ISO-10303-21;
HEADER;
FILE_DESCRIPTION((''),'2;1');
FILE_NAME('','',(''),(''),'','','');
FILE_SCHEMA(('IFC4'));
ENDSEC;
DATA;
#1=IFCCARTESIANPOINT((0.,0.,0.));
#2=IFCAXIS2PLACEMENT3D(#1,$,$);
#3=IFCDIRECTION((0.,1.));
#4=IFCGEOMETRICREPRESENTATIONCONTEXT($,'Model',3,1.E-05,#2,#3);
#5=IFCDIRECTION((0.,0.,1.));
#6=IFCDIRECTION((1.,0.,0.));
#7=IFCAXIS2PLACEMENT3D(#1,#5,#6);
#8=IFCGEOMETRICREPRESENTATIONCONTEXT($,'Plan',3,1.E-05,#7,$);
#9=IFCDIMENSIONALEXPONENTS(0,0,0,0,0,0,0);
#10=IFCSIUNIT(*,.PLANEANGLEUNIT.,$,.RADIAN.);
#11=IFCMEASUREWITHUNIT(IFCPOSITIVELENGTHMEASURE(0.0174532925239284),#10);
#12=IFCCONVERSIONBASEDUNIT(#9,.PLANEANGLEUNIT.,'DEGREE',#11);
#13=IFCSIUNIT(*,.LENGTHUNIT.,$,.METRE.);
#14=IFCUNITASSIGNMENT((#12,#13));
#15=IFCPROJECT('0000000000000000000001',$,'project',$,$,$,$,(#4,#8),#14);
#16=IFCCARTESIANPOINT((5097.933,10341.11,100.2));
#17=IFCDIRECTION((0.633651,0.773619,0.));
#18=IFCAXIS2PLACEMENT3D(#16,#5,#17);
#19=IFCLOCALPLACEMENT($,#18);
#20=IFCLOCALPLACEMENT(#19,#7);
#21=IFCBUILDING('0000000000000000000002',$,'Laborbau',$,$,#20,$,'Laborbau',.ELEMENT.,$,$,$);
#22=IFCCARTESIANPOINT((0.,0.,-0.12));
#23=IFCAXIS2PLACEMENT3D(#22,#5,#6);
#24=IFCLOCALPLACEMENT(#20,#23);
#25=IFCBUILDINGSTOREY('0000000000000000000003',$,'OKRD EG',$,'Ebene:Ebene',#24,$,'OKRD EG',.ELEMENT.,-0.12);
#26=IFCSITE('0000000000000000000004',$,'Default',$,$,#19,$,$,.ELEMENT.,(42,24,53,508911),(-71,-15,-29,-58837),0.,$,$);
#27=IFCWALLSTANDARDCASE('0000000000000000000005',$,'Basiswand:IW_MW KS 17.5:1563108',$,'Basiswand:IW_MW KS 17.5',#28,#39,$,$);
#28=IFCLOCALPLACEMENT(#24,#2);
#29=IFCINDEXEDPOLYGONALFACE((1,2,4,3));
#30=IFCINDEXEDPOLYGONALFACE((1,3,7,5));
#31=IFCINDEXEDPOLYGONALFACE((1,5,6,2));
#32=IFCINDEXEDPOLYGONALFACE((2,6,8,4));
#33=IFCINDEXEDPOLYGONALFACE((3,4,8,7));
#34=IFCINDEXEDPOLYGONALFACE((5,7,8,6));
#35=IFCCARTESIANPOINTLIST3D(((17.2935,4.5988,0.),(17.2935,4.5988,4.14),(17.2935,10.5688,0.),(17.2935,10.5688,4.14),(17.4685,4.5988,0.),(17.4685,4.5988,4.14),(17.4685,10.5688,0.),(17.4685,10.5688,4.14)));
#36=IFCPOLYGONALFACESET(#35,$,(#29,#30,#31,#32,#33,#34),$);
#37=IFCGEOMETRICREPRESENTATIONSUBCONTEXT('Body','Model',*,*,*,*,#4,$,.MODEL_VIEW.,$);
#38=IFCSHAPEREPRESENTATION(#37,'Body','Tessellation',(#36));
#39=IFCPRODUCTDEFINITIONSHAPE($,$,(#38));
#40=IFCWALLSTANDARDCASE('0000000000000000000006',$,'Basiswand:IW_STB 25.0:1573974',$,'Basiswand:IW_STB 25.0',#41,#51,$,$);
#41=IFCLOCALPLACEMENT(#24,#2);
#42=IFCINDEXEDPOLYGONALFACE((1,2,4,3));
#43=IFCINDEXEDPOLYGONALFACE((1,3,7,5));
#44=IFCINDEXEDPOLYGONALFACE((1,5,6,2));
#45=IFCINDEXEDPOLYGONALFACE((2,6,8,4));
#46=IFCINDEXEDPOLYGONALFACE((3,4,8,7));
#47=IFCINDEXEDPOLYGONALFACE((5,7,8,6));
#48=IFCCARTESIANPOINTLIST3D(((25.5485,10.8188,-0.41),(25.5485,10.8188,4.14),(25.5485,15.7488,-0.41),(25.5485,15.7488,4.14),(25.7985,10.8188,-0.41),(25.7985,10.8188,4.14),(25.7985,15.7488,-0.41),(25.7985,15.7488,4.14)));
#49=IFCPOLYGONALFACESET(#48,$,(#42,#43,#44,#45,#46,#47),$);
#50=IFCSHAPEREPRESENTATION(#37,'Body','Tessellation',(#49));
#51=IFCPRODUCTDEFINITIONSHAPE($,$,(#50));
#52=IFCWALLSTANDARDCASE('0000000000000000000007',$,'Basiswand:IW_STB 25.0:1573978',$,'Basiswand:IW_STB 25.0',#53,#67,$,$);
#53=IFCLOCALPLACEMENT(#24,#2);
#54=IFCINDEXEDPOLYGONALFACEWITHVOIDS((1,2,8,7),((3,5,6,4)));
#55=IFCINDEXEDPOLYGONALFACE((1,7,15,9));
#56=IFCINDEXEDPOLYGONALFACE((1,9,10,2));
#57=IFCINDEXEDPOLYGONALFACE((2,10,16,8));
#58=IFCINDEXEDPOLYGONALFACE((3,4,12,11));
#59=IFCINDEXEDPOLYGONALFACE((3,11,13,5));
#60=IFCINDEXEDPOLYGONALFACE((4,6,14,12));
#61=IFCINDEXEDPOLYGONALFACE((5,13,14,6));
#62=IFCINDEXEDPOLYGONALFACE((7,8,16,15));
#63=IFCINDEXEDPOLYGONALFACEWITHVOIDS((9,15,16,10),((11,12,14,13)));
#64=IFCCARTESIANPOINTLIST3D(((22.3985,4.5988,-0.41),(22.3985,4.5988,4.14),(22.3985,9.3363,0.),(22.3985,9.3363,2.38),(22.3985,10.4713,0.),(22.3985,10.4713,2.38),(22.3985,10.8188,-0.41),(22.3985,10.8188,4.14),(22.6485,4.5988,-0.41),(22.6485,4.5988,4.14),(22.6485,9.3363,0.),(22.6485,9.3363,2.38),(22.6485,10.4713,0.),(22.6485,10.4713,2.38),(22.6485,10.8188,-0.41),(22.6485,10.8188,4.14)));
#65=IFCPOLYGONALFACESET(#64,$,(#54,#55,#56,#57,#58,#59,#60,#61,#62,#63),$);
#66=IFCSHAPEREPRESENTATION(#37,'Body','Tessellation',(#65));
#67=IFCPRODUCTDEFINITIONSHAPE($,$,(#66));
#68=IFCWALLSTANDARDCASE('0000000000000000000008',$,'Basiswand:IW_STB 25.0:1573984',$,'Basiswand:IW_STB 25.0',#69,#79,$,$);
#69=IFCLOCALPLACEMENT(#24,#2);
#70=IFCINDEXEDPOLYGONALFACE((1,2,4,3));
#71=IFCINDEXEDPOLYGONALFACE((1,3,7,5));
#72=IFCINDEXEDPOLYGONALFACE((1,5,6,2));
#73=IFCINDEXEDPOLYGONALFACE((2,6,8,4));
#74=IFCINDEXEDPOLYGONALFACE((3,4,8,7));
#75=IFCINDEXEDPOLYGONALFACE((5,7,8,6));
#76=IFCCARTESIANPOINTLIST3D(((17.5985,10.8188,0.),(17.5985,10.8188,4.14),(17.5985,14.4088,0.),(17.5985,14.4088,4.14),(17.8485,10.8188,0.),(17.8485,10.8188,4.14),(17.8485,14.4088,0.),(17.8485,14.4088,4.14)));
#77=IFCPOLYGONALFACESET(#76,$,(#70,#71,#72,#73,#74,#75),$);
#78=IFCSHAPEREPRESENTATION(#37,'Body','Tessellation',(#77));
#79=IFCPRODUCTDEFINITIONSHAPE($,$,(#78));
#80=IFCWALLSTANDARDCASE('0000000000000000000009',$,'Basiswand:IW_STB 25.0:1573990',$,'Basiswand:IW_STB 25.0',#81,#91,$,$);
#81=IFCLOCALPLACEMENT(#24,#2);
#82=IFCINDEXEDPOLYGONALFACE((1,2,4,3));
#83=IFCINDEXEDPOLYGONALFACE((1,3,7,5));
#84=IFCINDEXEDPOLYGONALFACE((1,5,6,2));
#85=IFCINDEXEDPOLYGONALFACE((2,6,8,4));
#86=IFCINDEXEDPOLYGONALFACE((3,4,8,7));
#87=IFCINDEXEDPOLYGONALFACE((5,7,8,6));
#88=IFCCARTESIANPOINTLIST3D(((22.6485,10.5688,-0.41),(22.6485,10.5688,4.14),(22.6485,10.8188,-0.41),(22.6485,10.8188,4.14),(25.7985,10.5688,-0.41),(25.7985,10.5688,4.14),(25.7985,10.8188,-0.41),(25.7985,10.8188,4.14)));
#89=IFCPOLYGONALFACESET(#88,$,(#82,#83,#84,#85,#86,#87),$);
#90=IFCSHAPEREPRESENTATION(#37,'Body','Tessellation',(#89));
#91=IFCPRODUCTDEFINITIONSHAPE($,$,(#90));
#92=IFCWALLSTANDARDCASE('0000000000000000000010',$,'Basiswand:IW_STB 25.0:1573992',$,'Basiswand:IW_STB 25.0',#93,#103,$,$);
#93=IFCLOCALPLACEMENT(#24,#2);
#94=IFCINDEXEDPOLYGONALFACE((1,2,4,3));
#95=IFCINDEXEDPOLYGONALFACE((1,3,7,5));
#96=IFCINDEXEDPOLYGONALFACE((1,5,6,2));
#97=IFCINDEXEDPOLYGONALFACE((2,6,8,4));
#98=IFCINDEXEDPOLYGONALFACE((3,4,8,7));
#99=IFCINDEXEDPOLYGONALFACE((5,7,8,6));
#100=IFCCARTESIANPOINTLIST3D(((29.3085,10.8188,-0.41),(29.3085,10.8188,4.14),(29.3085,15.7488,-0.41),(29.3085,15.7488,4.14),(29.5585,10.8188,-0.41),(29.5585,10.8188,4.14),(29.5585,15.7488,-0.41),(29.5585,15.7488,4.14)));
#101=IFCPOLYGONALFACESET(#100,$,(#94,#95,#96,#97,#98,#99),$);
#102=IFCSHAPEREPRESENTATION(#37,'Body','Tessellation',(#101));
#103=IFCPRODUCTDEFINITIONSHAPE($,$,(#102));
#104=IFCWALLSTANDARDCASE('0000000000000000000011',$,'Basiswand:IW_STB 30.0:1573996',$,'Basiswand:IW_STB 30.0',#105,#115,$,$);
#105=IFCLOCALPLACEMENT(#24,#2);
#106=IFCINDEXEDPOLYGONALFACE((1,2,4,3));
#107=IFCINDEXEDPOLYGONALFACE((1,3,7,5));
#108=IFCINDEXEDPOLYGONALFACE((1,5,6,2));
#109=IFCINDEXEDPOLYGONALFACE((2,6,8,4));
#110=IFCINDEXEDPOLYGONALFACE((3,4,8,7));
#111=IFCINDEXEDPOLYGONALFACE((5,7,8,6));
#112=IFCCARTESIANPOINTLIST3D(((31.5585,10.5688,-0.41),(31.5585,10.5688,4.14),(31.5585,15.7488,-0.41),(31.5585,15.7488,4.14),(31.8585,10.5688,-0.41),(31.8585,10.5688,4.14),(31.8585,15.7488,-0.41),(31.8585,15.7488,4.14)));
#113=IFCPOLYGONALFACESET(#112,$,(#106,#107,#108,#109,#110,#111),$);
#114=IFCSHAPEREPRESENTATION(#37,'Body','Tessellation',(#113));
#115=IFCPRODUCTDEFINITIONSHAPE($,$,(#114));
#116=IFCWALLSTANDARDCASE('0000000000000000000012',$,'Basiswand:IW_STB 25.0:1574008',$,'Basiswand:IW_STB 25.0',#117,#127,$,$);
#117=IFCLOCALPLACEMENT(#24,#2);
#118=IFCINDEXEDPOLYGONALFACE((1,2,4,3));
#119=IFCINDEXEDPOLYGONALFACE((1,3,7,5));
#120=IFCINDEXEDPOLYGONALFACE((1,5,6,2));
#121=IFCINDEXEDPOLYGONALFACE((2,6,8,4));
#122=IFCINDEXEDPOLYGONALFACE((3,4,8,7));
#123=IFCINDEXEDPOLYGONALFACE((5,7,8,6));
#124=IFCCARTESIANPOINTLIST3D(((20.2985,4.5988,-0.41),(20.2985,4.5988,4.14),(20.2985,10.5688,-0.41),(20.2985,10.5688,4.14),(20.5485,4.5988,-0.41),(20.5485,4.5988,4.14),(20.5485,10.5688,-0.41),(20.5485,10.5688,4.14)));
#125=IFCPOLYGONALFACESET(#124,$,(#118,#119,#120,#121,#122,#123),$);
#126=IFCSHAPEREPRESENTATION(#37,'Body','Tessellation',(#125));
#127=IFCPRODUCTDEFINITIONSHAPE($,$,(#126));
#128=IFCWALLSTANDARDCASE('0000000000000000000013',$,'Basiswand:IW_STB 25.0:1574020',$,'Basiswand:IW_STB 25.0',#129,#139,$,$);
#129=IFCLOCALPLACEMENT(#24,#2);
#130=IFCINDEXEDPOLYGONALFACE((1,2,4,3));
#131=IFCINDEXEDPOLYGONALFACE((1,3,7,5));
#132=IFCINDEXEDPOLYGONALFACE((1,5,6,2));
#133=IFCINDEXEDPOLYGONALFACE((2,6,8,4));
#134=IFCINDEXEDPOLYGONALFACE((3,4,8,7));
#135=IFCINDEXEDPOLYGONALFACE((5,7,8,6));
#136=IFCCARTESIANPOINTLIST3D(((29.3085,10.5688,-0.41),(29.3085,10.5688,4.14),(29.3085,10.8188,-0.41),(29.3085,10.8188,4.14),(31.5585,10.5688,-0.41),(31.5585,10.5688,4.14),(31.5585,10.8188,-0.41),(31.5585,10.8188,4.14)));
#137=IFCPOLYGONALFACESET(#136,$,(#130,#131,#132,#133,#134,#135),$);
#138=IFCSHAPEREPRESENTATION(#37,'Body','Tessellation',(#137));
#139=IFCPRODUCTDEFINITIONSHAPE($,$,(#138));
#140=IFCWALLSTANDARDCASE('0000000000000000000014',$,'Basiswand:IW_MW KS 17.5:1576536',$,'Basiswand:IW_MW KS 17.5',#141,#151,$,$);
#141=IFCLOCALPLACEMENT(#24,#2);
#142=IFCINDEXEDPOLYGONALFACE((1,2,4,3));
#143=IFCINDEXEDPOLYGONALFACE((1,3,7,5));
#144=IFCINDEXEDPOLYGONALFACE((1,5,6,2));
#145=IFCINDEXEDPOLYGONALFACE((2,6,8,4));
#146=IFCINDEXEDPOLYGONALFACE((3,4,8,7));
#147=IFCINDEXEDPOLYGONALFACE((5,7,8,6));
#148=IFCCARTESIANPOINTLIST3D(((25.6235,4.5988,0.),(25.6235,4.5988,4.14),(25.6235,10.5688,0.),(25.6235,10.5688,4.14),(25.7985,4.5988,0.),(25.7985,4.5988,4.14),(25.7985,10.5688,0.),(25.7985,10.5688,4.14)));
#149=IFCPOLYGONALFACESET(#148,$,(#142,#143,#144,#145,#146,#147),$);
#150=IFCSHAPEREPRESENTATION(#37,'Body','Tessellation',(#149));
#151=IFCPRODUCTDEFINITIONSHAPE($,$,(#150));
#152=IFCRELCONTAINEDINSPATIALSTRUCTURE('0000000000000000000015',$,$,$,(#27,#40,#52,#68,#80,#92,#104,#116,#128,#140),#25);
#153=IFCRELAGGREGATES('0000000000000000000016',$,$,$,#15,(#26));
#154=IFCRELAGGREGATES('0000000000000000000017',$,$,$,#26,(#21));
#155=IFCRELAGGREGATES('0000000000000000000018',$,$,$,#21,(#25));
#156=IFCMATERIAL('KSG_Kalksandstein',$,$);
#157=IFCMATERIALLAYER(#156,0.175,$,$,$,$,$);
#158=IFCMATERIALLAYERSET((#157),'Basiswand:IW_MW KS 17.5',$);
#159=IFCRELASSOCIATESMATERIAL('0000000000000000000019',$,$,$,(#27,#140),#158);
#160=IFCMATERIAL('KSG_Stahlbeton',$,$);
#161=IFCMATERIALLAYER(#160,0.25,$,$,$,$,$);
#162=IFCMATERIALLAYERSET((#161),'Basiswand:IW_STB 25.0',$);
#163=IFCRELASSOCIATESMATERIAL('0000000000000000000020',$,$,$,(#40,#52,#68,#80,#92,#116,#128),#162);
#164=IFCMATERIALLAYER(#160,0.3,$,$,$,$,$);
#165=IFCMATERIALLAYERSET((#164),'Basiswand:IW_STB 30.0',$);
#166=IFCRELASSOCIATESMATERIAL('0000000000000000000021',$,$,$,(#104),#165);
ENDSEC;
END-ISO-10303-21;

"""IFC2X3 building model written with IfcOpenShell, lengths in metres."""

from ifc_helpers import new_model, entity, si_unit, converted_unit, direction, frame, frame_2d, origin, origin_with_axes, place, context, subcontext, project, spatial, rectangle, extrude, clip, halfspace, material, layer, layer_set, layer_usage, element, save


model = new_model("IFC2X3")

# Units and contexts
model_context = context("Model", 3, precision=1e-05, world=origin(), true_north=direction((0.0, 1.0)))
plan_context = context("Plan", 3, precision=1e-05, world=origin_with_axes())
body_context = subcontext(model_context, "Body", "Model", "MODEL_VIEW")
ifc_project = project(units=[converted_unit("PLANEANGLEUNIT", "DEGREE", entity("IfcPositiveLengthMeasure", 0.0174532925239284), si_unit("PLANEANGLEUNIT", "RADIAN"), dimensions=[0, 0, 0, 0, 0, 0, 0]), si_unit("LENGTHUNIT", "METRE")], contexts=[model_context, plan_context])

# Site, building, storey
site_placement = place(None, frame((5097.933, 10341.11, 100.2), z_axis=(0.0, 0.0, 1.0), x_axis=(0.633651, 0.773619, 0.0)))
site = spatial("IfcSite", under=ifc_project, at=site_placement, Name="Default", CompositionType="ELEMENT", RefLatitude=(42, 24, 53, 508911), RefLongitude=(-71, -15, -29, -58837), RefElevation=0.0)
building_placement = place(site_placement, origin_with_axes())
building = spatial("IfcBuilding", under=site, at=building_placement, Name="Laborbau", LongName="Laborbau", CompositionType="ELEMENT")
storey_placement = place(building_placement, frame((0.0, 0.0, -0.12), z_axis=(0.0, 0.0, 1.0), x_axis=(1.0, 0.0, 0.0)))
storey = spatial("IfcBuildingStorey", under=building, at=storey_placement, Name="OKRD EG", ObjectType="Ebene:Ebene", LongName="OKRD EG", CompositionType="ELEMENT", Elevation=-0.12)

# Walls
ifc_material_1 = material(Name="KSG_Kalksandstein")
ifc_layer_1 = layer(ifc_material_1, 0.175)
ifc_layer_set_1 = layer_set([ifc_layer_1], Name="Basiswand:IW_MW KS 17.5")
ifc_layer_usage_1 = layer_usage(ifc_layer_set_1, "AXIS2", "NEGATIVE", 0.0875)
wall_1_placement = place(storey_placement, frame((17.381, 10.5688, 0.0), z_axis=(0.0, 0.0, 1.0), x_axis=(0.0, -1.0, 0.0)))
element("IfcWallStandardCase", 1, at=wall_1_placement, inside=storey, material=ifc_layer_usage_1, Name="Basiswand:IW_MW KS 17.5:1563108", ObjectType="Basiswand:IW_MW KS 17.5", context=body_context, shape_type="SweptSolid", body=[
    extrude(rectangle(XDim=5.97, YDim=0.175, at=frame_2d((2.985, 0.0), x_axis=(-1.0, 0.0))), origin(), (0.0, 0.0, 1.0), 4.14),
])
ifc_material_2 = material(Name="KSG_Stahlbeton")
ifc_layer_2 = layer(ifc_material_2, 0.25)
ifc_layer_set_2 = layer_set([ifc_layer_2], Name="Basiswand:IW_STB 25.0")
ifc_layer_usage_2 = layer_usage(ifc_layer_set_2, "AXIS2", "NEGATIVE", 0.125)
wall_2_placement = place(storey_placement, frame((25.6735, 10.8188, -0.41), z_axis=(0.0, 0.0, 1.0), x_axis=(0.0, 1.0, 0.0)))
element("IfcWallStandardCase", 2, at=wall_2_placement, inside=storey, material=ifc_layer_usage_2, Name="Basiswand:IW_STB 25.0:1573974", ObjectType="Basiswand:IW_STB 25.0", context=body_context, shape_type="SweptSolid", body=[
    extrude(rectangle(XDim=4.93, YDim=0.25, at=frame_2d((2.465, 0.0), x_axis=(-1.0, 0.0))), origin(), (0.0, 0.0, 1.0), 4.55),
])

# Wall, openings
ifc_layer_usage_3 = layer_usage(ifc_layer_set_2, "AXIS2", "NEGATIVE", 0.125)
wall_3_placement = place(storey_placement, frame((22.5235, 4.5988, -0.41), z_axis=(0.0, 0.0, 1.0), x_axis=(0.0, 1.0, 0.0)))
wall_3 = element("IfcWallStandardCase", 3, at=wall_3_placement, inside=storey, material=ifc_layer_usage_3, Name="Basiswand:IW_STB 25.0:1573978", ObjectType="Basiswand:IW_STB 25.0", context=body_context, shape_type="SweptSolid", body=[
    extrude(rectangle(XDim=6.22, YDim=0.25, at=frame_2d((3.11, 0.0), x_axis=(-1.0, 0.0))), origin(), (0.0, 0.0, 1.0), 4.55),
])
opening_1_placement = place(wall_3_placement, frame((-4.5988, 22.5235, 0.41), z_axis=(0.0, 0.0, 1.0), x_axis=(0.0, -1.0, 0.0)))
element("IfcOpeningElement", 4, at=opening_1_placement, cuts=wall_3, ObjectType="Opening", context=body_context, shape_type="SweptSolid", body=[
    extrude(rectangle(XDim=2.38, YDim=1.135, at=frame_2d((0.0, 0.0), x_axis=(1.0, 0.0))), frame((23.9225, 9.9038, 1.19), z_axis=(-1.0, 0.0, 0.0), x_axis=(0.0, 0.0, 1.0)), (0.0, 0.0, 1.0), 3.048),
])
opening_2_placement = place(wall_3_placement, frame((5.8725, 0.125, 0.41), z_axis=(0.0, 0.0, 1.0), x_axis=(1.0, 0.0, 0.0)))
element("IfcOpeningElement", 5, at=opening_2_placement, cuts=wall_3, ObjectType="Opening", context=body_context, shape_type="SweptSolid", body=[
    extrude(rectangle(XDim=2.38, YDim=1.135, at=frame_2d((1.19, 0.5675), x_axis=(1.0, 0.0))), frame((0.0, 0.0, 0.0), z_axis=(0.0, -1.0, 0.0), x_axis=(0.0, 0.0, 1.0)), (0.0, 0.0, 1.0), 0.25),
])

# Walls
ifc_layer_usage_4 = layer_usage(ifc_layer_set_2, "AXIS2", "POSITIVE", -0.125)
wall_4_placement = place(storey_placement, frame((17.7235, 10.8188, 0.0), z_axis=(0.0, 0.0, 1.0), x_axis=(0.0, 1.0, 0.0)))
element("IfcWallStandardCase", 6, at=wall_4_placement, inside=storey, material=ifc_layer_usage_4, Name="Basiswand:IW_STB 25.0:1573984", ObjectType="Basiswand:IW_STB 25.0", context=body_context, shape_type="Clipping", body=[
    clip(extrude(rectangle(XDim=3.59, YDim=0.25, at=frame_2d((1.795, 0.0), x_axis=(-1.0, 0.0))), origin(), (0.0, 0.0, 1.0), 4.14), halfspace(frame((0.0, 0.0, -1.58)), True)),
])
ifc_layer_usage_5 = layer_usage(ifc_layer_set_2, "AXIS2", "NEGATIVE", 0.125)
wall_5_placement = place(storey_placement, frame((22.6485, 10.6938, -0.41), z_axis=(0.0, 0.0, 1.0), x_axis=(1.0, 0.0, 0.0)))
element("IfcWallStandardCase", 7, at=wall_5_placement, inside=storey, material=ifc_layer_usage_5, Name="Basiswand:IW_STB 25.0:1573990", ObjectType="Basiswand:IW_STB 25.0", context=body_context, shape_type="SweptSolid", body=[
    extrude(rectangle(XDim=3.15, YDim=0.25, at=frame_2d((1.575, 0.0), x_axis=(-1.0, 0.0))), origin(), (0.0, 0.0, 1.0), 4.55),
])
ifc_layer_usage_6 = layer_usage(ifc_layer_set_2, "AXIS2", "NEGATIVE", 0.125)
wall_6_placement = place(storey_placement, frame((29.4335, 10.8188, -0.41), z_axis=(0.0, 0.0, 1.0), x_axis=(0.0, 1.0, 0.0)))
element("IfcWallStandardCase", 8, at=wall_6_placement, inside=storey, material=ifc_layer_usage_6, Name="Basiswand:IW_STB 25.0:1573992", ObjectType="Basiswand:IW_STB 25.0", context=body_context, shape_type="SweptSolid", body=[
    extrude(rectangle(XDim=4.93, YDim=0.25, at=frame_2d((2.465, 0.0), x_axis=(-1.0, 0.0))), origin(), (0.0, 0.0, 1.0), 4.55),
])
ifc_layer_3 = layer(ifc_material_2, 0.3)
ifc_layer_set_3 = layer_set([ifc_layer_3], Name="Basiswand:IW_STB 30.0")
ifc_layer_usage_7 = layer_usage(ifc_layer_set_3, "AXIS2", "NEGATIVE", 0.15)
wall_7_placement = place(storey_placement, frame((31.7085, 10.5688, -0.41), z_axis=(0.0, 0.0, 1.0), x_axis=(0.0, 1.0, 0.0)))
element("IfcWallStandardCase", 9, at=wall_7_placement, inside=storey, material=ifc_layer_usage_7, Name="Basiswand:IW_STB 30.0:1573996", ObjectType="Basiswand:IW_STB 30.0", context=body_context, shape_type="SweptSolid", body=[
    extrude(rectangle(XDim=5.18, YDim=0.3, at=frame_2d((2.59, 0.0), x_axis=(-1.0, 0.0))), origin(), (0.0, 0.0, 1.0), 4.55),
])
ifc_layer_usage_8 = layer_usage(ifc_layer_set_2, "AXIS2", "POSITIVE", -0.125)
wall_8_placement = place(storey_placement, frame((20.4235, 4.5988, -0.41), z_axis=(0.0, 0.0, 1.0), x_axis=(0.0, 1.0, 0.0)))
element("IfcWallStandardCase", 10, at=wall_8_placement, inside=storey, material=ifc_layer_usage_8, Name="Basiswand:IW_STB 25.0:1574008", ObjectType="Basiswand:IW_STB 25.0", context=body_context, shape_type="SweptSolid", body=[
    extrude(rectangle(XDim=5.97, YDim=0.25, at=frame_2d((2.985, 0.0), x_axis=(-1.0, 0.0))), origin(), (0.0, 0.0, 1.0), 4.55),
])
ifc_layer_usage_9 = layer_usage(ifc_layer_set_2, "AXIS2", "NEGATIVE", 0.125)
wall_9_placement = place(storey_placement, frame((29.3085, 10.6938, -0.41), z_axis=(0.0, 0.0, 1.0), x_axis=(1.0, 0.0, 0.0)))
element("IfcWallStandardCase", 11, at=wall_9_placement, inside=storey, material=ifc_layer_usage_9, Name="Basiswand:IW_STB 25.0:1574020", ObjectType="Basiswand:IW_STB 25.0", context=body_context, shape_type="SweptSolid", body=[
    extrude(rectangle(XDim=2.25, YDim=0.25, at=frame_2d((1.125, 0.0), x_axis=(-1.0, 0.0))), origin(), (0.0, 0.0, 1.0), 4.55),
])
ifc_layer_usage_10 = layer_usage(ifc_layer_set_1, "AXIS2", "NEGATIVE", 0.0875)
wall_10_placement = place(storey_placement, frame((25.711, 10.5688, 0.0), z_axis=(0.0, 0.0, 1.0), x_axis=(0.0, -1.0, 0.0)))
element("IfcWallStandardCase", 12, at=wall_10_placement, inside=storey, material=ifc_layer_usage_10, Name="Basiswand:IW_MW KS 17.5:1576536", ObjectType="Basiswand:IW_MW KS 17.5", context=body_context, shape_type="SweptSolid", body=[
    extrude(rectangle(XDim=5.97, YDim=0.175, at=frame_2d((2.985, 0.0), x_axis=(-1.0, 0.0))), origin(), (0.0, 0.0, 1.0), 4.14),
])

save(model, "model.ifc")
